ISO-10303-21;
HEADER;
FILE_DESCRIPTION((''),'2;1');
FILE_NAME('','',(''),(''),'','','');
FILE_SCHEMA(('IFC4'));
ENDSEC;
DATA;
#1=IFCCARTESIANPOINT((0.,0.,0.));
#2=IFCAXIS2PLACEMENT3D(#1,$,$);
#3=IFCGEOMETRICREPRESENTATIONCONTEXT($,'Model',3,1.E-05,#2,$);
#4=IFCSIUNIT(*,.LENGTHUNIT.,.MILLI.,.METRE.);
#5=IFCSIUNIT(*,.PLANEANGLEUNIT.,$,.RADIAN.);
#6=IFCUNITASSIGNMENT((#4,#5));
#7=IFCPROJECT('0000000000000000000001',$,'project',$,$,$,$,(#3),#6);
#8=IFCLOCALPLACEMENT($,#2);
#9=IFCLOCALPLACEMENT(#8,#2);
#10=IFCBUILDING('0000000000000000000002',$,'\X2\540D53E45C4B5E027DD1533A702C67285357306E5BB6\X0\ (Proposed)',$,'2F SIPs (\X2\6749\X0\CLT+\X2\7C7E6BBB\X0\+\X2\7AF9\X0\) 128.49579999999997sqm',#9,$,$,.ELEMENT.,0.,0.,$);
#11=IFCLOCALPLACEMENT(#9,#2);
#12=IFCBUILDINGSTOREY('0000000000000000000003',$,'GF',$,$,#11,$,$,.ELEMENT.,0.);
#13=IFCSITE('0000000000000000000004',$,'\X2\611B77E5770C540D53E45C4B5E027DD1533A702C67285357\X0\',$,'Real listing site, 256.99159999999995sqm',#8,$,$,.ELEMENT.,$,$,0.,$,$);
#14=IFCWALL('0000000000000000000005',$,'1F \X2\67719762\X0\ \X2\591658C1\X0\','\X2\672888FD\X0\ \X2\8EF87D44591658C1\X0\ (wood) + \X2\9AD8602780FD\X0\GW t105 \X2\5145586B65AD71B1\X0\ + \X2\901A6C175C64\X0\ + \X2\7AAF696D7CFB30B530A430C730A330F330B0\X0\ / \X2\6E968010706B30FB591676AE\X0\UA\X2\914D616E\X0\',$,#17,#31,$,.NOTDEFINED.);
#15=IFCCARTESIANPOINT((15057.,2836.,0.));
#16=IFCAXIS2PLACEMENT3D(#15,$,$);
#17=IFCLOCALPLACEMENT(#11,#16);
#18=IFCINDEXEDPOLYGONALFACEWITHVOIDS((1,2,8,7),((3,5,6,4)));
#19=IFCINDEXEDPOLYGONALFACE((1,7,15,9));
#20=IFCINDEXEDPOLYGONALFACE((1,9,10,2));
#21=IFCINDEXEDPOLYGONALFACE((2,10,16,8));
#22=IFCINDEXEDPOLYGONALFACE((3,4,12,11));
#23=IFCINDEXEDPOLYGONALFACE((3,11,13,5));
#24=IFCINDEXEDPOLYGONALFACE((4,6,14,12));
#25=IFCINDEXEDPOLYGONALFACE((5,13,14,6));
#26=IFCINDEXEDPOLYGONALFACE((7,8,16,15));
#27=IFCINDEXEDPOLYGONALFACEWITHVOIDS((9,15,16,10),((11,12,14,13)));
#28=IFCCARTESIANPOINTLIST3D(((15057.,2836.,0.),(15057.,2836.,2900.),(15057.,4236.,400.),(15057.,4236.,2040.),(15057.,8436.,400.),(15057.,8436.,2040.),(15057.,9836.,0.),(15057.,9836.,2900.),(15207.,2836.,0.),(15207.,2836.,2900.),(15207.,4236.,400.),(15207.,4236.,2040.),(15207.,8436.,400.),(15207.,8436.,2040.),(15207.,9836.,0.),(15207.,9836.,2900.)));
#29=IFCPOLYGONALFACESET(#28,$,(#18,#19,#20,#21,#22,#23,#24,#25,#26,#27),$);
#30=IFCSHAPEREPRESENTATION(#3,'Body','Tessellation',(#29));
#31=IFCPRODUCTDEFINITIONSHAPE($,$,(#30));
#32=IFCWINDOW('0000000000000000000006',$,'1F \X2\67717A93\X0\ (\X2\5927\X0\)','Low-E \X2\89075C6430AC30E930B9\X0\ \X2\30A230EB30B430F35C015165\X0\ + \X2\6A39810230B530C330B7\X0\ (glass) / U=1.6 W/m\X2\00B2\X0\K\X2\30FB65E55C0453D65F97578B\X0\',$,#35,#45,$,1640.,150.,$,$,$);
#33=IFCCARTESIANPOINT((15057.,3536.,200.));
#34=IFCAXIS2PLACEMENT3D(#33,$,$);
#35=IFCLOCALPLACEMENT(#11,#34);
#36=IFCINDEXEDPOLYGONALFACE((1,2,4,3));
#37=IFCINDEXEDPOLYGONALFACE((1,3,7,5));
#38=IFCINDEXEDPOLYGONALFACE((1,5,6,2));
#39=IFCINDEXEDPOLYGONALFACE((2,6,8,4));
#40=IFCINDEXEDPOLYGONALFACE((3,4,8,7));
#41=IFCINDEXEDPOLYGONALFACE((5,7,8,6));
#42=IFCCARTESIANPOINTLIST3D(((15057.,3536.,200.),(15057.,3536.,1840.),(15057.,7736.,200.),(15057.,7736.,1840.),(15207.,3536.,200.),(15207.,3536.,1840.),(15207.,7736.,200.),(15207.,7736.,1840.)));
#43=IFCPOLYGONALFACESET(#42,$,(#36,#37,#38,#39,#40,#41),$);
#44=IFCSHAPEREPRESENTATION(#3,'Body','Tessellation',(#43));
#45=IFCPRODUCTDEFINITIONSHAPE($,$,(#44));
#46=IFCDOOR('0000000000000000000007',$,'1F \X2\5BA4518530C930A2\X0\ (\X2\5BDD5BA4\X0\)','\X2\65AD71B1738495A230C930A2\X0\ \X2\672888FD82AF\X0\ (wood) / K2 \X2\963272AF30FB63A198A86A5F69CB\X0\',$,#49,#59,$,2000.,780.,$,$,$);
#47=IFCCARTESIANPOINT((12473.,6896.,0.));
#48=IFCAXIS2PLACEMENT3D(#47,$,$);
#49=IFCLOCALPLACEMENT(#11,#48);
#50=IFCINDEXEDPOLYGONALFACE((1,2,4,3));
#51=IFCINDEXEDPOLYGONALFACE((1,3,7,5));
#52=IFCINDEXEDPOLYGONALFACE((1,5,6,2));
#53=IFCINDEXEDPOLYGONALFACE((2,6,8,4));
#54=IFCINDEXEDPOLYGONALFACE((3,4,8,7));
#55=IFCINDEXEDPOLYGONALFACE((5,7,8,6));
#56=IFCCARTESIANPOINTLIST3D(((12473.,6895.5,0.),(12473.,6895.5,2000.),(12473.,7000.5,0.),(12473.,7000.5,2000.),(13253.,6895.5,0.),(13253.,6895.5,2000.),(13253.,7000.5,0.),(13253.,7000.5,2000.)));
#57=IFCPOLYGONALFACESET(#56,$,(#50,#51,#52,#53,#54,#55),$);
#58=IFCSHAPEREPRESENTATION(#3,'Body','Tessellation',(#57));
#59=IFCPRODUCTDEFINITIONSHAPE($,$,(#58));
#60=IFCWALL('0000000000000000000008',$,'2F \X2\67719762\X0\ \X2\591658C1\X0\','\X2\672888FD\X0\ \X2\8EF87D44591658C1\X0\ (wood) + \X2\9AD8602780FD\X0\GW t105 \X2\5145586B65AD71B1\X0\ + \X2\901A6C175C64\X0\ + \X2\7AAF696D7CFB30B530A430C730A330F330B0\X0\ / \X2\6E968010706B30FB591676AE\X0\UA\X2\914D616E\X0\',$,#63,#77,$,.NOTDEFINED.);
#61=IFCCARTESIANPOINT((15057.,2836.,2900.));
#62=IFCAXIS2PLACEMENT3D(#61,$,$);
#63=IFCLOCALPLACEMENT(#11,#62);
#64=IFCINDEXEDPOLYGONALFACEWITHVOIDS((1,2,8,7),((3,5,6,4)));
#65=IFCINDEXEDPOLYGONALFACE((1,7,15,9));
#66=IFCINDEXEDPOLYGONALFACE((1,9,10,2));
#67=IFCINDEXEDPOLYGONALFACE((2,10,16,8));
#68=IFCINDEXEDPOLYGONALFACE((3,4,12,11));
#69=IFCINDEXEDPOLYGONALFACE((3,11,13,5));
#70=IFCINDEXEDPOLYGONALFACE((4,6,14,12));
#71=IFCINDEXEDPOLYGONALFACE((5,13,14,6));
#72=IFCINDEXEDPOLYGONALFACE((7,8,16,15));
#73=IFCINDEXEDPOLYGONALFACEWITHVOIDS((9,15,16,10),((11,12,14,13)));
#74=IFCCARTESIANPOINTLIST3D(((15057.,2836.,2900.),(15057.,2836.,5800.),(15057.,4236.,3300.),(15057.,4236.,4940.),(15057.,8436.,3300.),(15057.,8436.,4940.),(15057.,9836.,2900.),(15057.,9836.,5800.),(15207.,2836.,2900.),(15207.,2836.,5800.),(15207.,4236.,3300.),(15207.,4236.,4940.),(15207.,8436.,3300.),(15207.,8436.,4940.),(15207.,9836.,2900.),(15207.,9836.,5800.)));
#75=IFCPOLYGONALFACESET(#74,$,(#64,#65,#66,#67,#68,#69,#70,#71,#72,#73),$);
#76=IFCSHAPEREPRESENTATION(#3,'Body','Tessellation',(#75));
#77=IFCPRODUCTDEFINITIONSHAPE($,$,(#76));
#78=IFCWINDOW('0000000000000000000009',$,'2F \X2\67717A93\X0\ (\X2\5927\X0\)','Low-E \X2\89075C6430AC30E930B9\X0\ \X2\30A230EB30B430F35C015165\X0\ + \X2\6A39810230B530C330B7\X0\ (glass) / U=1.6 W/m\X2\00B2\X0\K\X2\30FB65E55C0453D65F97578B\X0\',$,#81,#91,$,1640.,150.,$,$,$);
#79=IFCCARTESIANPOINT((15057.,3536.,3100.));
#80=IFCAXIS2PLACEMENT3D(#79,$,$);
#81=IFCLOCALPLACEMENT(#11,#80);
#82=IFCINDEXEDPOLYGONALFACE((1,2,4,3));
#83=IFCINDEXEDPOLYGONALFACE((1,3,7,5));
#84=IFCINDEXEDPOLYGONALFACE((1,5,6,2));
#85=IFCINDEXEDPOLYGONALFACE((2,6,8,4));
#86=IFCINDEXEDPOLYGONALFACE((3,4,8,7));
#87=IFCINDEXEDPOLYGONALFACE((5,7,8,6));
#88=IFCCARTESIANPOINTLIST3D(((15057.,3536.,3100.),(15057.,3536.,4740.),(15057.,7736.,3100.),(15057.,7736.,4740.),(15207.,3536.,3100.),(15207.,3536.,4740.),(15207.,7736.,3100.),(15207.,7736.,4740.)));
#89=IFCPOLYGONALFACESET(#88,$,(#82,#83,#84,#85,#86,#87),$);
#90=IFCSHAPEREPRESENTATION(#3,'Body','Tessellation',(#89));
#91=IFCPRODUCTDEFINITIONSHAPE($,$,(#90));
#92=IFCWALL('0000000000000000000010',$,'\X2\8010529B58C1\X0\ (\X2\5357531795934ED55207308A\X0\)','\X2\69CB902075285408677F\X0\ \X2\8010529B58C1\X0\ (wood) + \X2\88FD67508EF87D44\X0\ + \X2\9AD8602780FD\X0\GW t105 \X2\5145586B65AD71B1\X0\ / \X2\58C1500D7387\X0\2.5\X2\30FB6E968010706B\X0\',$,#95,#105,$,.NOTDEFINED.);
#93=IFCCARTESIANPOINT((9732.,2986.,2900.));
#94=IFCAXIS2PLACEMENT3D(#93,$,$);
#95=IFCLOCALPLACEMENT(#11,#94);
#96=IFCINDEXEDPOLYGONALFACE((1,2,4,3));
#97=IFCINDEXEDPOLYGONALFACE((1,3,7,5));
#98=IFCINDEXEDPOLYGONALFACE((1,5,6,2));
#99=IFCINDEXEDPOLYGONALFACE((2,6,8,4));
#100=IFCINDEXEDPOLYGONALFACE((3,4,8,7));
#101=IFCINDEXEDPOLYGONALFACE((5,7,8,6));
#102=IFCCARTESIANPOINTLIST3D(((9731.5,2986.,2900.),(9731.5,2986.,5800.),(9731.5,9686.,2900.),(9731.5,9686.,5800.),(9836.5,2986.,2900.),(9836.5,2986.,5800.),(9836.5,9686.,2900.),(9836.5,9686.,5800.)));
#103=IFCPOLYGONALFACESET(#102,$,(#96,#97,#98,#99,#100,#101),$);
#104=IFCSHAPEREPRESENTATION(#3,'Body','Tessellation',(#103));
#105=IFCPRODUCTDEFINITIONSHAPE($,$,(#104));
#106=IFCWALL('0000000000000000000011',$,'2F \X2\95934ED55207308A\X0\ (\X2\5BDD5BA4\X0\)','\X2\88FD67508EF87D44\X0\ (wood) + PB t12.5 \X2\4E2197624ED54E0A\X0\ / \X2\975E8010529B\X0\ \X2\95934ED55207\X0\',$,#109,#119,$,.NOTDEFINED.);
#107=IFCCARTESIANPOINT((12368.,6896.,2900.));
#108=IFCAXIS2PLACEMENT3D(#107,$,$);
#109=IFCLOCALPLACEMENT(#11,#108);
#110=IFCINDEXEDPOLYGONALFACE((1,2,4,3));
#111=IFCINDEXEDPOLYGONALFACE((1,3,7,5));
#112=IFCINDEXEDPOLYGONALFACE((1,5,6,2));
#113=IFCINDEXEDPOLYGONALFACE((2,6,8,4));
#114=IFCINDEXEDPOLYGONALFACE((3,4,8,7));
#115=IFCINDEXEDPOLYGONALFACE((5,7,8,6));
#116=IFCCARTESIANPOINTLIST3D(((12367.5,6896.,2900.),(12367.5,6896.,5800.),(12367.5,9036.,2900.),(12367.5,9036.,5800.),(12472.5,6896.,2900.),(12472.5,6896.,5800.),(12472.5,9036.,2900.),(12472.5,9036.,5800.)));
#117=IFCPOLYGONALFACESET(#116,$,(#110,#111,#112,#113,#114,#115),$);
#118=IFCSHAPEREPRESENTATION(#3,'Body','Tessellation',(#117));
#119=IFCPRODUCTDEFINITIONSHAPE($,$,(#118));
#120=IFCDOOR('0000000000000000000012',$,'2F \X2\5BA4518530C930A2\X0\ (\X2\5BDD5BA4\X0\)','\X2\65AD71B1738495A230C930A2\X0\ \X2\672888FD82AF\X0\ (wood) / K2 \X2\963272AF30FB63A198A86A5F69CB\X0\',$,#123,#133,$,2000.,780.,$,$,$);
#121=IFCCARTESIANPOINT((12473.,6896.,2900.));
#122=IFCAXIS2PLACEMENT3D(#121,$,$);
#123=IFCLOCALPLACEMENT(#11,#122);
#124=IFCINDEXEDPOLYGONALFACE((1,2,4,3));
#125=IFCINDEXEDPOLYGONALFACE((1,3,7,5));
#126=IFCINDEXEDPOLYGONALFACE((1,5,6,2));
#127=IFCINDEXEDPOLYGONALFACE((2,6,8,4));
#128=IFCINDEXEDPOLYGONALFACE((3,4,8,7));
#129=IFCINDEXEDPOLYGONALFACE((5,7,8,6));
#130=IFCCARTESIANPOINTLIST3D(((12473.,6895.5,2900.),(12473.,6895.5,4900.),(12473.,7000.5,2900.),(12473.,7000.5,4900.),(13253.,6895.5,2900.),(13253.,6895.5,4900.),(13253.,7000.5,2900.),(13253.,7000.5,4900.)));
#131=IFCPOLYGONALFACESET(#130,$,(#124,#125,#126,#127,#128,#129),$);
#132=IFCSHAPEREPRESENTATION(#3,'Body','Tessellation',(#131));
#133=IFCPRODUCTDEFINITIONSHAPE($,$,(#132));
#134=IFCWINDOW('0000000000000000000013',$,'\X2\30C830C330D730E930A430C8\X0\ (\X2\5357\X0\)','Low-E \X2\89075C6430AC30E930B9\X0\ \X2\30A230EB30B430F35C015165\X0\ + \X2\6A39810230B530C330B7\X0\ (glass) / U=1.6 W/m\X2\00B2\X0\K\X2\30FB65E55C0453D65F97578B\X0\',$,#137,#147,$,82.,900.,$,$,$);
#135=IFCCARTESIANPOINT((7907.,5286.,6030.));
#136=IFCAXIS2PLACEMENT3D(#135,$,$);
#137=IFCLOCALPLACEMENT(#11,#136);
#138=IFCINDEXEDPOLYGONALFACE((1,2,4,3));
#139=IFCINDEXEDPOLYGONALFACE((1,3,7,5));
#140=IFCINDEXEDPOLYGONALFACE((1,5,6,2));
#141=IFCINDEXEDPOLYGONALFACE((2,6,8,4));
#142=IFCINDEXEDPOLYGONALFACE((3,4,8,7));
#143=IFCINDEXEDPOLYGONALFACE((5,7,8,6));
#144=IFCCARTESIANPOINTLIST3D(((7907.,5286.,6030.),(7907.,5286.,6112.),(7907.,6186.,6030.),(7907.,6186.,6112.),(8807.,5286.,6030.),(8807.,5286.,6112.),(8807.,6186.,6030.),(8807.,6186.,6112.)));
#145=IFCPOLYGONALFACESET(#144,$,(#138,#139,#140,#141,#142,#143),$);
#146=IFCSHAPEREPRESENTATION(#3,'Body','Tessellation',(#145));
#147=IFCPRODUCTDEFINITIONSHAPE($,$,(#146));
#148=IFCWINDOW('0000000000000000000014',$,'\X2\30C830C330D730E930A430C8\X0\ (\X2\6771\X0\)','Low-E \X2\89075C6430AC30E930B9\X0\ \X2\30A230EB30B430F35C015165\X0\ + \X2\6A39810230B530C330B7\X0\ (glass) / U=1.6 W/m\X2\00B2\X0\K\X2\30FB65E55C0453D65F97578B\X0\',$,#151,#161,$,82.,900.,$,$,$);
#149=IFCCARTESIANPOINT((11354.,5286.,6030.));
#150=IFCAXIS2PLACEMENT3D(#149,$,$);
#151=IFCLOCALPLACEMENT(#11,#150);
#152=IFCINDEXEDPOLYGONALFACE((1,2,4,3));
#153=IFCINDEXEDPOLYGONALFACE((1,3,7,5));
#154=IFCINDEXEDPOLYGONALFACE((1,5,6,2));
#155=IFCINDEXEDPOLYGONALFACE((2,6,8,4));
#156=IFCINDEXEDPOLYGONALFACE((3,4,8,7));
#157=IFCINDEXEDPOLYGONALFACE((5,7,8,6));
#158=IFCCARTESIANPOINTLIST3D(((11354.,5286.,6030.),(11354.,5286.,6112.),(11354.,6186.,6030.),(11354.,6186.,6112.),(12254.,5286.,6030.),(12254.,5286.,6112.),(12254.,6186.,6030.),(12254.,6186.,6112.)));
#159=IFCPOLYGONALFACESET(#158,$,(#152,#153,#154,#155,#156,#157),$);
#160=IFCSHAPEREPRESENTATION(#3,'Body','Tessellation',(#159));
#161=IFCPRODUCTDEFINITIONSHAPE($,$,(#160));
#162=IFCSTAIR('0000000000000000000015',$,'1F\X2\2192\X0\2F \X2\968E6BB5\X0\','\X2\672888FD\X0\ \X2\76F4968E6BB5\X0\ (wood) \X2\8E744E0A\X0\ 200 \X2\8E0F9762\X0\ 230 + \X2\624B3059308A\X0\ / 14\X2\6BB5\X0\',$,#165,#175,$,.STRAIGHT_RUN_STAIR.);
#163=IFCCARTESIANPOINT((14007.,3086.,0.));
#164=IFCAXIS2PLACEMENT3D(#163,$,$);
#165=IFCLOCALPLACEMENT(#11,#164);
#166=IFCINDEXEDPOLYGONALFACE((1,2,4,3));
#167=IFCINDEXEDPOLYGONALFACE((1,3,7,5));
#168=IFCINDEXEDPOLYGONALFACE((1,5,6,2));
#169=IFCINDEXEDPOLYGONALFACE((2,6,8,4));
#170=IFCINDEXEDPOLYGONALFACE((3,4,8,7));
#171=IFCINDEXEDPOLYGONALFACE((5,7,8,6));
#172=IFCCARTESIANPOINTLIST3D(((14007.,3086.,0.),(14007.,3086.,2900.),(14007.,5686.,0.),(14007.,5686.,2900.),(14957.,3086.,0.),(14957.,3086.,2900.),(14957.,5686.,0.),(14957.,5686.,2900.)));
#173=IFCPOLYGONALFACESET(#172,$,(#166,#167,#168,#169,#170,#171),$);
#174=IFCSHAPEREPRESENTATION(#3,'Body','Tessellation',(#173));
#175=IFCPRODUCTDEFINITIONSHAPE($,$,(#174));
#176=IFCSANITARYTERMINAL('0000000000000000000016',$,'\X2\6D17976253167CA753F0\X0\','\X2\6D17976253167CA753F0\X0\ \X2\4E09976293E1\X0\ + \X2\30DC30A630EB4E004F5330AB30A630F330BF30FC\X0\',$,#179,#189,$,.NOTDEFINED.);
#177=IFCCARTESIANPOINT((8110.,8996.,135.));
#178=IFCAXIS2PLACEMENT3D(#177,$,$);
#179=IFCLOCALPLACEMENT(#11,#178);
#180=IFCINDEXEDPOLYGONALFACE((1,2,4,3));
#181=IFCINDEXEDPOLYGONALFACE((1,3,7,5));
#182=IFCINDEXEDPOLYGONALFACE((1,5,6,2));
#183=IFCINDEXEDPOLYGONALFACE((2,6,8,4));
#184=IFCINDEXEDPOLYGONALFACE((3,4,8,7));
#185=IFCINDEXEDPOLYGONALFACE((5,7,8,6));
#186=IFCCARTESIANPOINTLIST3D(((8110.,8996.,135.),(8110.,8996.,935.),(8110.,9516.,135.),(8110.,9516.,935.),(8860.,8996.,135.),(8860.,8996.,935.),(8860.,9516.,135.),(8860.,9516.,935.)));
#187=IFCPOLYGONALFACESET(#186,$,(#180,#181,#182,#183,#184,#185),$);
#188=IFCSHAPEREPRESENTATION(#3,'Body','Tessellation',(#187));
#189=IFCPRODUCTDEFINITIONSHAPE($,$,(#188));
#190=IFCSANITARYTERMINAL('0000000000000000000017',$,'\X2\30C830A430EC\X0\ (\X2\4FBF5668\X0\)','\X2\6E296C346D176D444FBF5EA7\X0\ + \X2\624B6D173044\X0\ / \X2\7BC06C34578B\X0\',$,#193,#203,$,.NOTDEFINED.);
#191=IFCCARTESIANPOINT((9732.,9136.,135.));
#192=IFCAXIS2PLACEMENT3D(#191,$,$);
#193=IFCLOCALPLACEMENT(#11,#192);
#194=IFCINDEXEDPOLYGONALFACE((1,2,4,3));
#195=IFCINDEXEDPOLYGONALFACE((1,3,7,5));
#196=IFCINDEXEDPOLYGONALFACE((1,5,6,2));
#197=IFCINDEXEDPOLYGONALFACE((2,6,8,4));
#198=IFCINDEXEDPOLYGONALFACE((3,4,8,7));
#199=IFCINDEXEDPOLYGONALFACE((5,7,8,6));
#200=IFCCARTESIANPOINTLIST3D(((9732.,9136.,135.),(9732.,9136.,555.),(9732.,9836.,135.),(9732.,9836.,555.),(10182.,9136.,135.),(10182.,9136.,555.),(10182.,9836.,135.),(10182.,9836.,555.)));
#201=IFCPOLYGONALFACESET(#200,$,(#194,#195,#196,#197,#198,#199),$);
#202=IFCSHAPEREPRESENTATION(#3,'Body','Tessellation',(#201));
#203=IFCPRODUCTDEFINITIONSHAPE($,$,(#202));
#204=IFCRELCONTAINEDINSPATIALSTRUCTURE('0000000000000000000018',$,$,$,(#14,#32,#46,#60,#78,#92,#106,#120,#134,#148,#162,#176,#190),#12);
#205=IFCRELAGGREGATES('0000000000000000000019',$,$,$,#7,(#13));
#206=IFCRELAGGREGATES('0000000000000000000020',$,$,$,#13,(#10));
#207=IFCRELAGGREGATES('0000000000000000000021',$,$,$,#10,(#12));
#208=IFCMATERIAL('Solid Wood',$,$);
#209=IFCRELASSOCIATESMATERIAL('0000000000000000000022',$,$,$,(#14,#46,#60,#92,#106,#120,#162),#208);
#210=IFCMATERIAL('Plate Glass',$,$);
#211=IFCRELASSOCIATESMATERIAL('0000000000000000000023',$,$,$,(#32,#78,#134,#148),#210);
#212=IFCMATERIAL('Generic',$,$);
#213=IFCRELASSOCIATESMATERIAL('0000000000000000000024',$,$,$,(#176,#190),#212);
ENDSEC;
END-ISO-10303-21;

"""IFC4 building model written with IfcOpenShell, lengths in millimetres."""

from ifc_helpers import new_model, si_unit, frame, frame_2d, origin, place, context, project, spatial, rectangle, extrude, material, element, fill, save


model = new_model("IFC4")

# Units and contexts
model_context = context("Model", 3, precision=1e-05, world=origin())
ifc_project = project(units=[si_unit("LENGTHUNIT", "METRE", prefix="MILLI"), si_unit("PLANEANGLEUNIT", "RADIAN")], contexts=[model_context])

# Site, building, storey
site_placement = place(None, origin())
site = spatial("IfcSite", under=ifc_project, at=site_placement, Name="愛知県名古屋市緑区瀬木南", ObjectType="Real listing site, 256.99159999999995sqm", CompositionType="ELEMENT", RefElevation=0.0)
building_placement = place(site_placement, origin())
building = spatial("IfcBuilding", under=site, at=building_placement, Name="名古屋市緑区瀬木南の家 (Proposed)", ObjectType="2F SIPs (杉CLT+籾殻+竹) 128.49579999999997sqm", CompositionType="ELEMENT", ElevationOfRefHeight=0.0, ElevationOfTerrain=0.0)
storey_placement = place(building_placement, origin())
storey = spatial("IfcBuildingStorey", under=building, at=storey_placement, Name="GF", CompositionType="ELEMENT", Elevation=0.0)

# Wall, opening, window
ifc_material_1 = material(Name="Solid Wood")
wall_1_placement = place(storey_placement, frame((15057.0, 2836.0, 0.0)))
wall_1 = element("IfcWall", 1, at=wall_1_placement, inside=storey, material=ifc_material_1, Name="1F 東面 外壁", Description="木製 軸組外壁 (wood) + 高性能GW t105 充填断熱 + 通気層 + 窯業系サイディング / 準耐火・外皮UA配慮", PredefinedType="NOTDEFINED", context=model_context, shape_type="SweptSolid", body=[
    extrude(rectangle(XDim=150.0, YDim=7000.0, at=frame_2d((75.0, 3500.0))), frame((15057.0, 2836.0, 0.0)), (0.0, 0.0, 1.0), 2900.0),
])
opening_1_placement = place(storey_placement, frame((15057.0, 3536.0, 200.0)))
opening_1 = element("IfcOpeningElement", 2, at=opening_1_placement, cuts=wall_1, PredefinedType="NOTDEFINED", context=model_context, shape_type="SweptSolid", body=[
    extrude(rectangle(XDim=150.0, YDim=4200.0, at=frame_2d((75.0, 2100.0))), frame((15057.0, 3536.0, 200.0)), (0.0, 0.0, 1.0), 1640.0),
])
ifc_material_2 = material(Name="Plate Glass")
window_1_placement = place(storey_placement, frame((15057.0, 3536.0, 200.0)))
window_1 = element("IfcWindow", 3, at=window_1_placement, inside=storey, material=ifc_material_2, Name="1F 東窓 (大)", Description="Low-E 複層ガラス アルゴン封入 + 樹脂サッシ (glass) / U=1.6 W/m²K・日射取得型", OverallHeight=1640.0, OverallWidth=150.0, context=model_context, shape_type="SweptSolid", body=[
    extrude(rectangle(XDim=150.0, YDim=4200.0, at=frame_2d((75.0, 2100.0))), frame((15057.0, 3536.0, 200.0)), (0.0, 0.0, 1.0), 1640.0),
])
fill(opening_1, window_1)

# Door
door_1_placement = place(storey_placement, frame((12473.0, 6896.0, 0.0)))
element("IfcDoor", 4, at=door_1_placement, inside=storey, material=ifc_material_1, Name="1F 室内ドア (寝室)", Description="断熱玄関ドア 木製芯 (wood) / K2 防犯・採風機構", OverallHeight=2000.0, OverallWidth=780.0, context=model_context, shape_type="SweptSolid", body=[
    extrude(rectangle(XDim=780.0, YDim=105.0, at=frame_2d((390.0, 52.0))), frame((12473.0, 6896.0, 0.0)), (0.0, 0.0, 1.0), 2000.0),
])

# Wall, opening, window
wall_2_placement = place(storey_placement, frame((15057.0, 2836.0, 2900.0)))
wall_2 = element("IfcWall", 5, at=wall_2_placement, inside=storey, material=ifc_material_1, Name="2F 東面 外壁", Description="木製 軸組外壁 (wood) + 高性能GW t105 充填断熱 + 通気層 + 窯業系サイディング / 準耐火・外皮UA配慮", PredefinedType="NOTDEFINED", context=model_context, shape_type="SweptSolid", body=[
    extrude(rectangle(XDim=150.0, YDim=7000.0, at=frame_2d((75.0, 3500.0))), frame((15057.0, 2836.0, 2900.0)), (0.0, 0.0, 1.0), 2900.0),
])
opening_2_placement = place(storey_placement, frame((15057.0, 3536.0, 3100.0)))
opening_2 = element("IfcOpeningElement", 6, at=opening_2_placement, cuts=wall_2, PredefinedType="NOTDEFINED", context=model_context, shape_type="SweptSolid", body=[
    extrude(rectangle(XDim=150.0, YDim=4200.0, at=frame_2d((75.0, 2100.0))), frame((15057.0, 3536.0, 3100.0)), (0.0, 0.0, 1.0), 1640.0),
])
window_2_placement = place(storey_placement, frame((15057.0, 3536.0, 3100.0)))
window_2 = element("IfcWindow", 7, at=window_2_placement, inside=storey, material=ifc_material_2, Name="2F 東窓 (大)", Description="Low-E 複層ガラス アルゴン封入 + 樹脂サッシ (glass) / U=1.6 W/m²K・日射取得型", OverallHeight=1640.0, OverallWidth=150.0, context=model_context, shape_type="SweptSolid", body=[
    extrude(rectangle(XDim=150.0, YDim=4200.0, at=frame_2d((75.0, 2100.0))), frame((15057.0, 3536.0, 3100.0)), (0.0, 0.0, 1.0), 1640.0),
])
fill(opening_2, window_2)

# Walls
wall_3_placement = place(storey_placement, frame((9732.0, 2986.0, 2900.0)))
element("IfcWall", 8, at=wall_3_placement, inside=storey, material=ifc_material_1, Name="耐力壁 (南北間仕切り)", Description="構造用合板 耐力壁 (wood) + 製材軸組 + 高性能GW t105 充填断熱 / 壁倍率2.5・準耐火", PredefinedType="NOTDEFINED", context=model_context, shape_type="SweptSolid", body=[
    extrude(rectangle(XDim=105.0, YDim=6700.0, at=frame_2d((52.0, 3350.0))), frame((9732.0, 2986.0, 2900.0)), (0.0, 0.0, 1.0), 2900.0),
])
wall_4_placement = place(storey_placement, frame((12368.0, 6896.0, 2900.0)))
element("IfcWall", 9, at=wall_4_placement, inside=storey, material=ifc_material_1, Name="2F 間仕切り (寝室)", Description="製材軸組 (wood) + PB t12.5 両面仕上 / 非耐力 間仕切", PredefinedType="NOTDEFINED", context=model_context, shape_type="SweptSolid", body=[
    extrude(rectangle(XDim=105.0, YDim=2140.0, at=frame_2d((52.0, 1070.0))), frame((12368.0, 6896.0, 2900.0)), (0.0, 0.0, 1.0), 2900.0),
])

# Door
door_2_placement = place(storey_placement, frame((12473.0, 6896.0, 2900.0)))
element("IfcDoor", 10, at=door_2_placement, inside=storey, material=ifc_material_1, Name="2F 室内ドア (寝室)", Description="断熱玄関ドア 木製芯 (wood) / K2 防犯・採風機構", OverallHeight=2000.0, OverallWidth=780.0, context=model_context, shape_type="SweptSolid", body=[
    extrude(rectangle(XDim=780.0, YDim=105.0, at=frame_2d((390.0, 52.0))), frame((12473.0, 6896.0, 2900.0)), (0.0, 0.0, 1.0), 2000.0),
])

# Windows
window_3_placement = place(storey_placement, frame((7907.0, 5286.0, 6030.0)))
element("IfcWindow", 11, at=window_3_placement, inside=storey, material=ifc_material_2, Name="トップライト (南)", Description="Low-E 複層ガラス アルゴン封入 + 樹脂サッシ (glass) / U=1.6 W/m²K・日射取得型", OverallHeight=82.0, OverallWidth=900.0, context=model_context, shape_type="SweptSolid", body=[
    extrude(rectangle(XDim=900.0, YDim=900.0, at=frame_2d((450.0, 450.0))), frame((7907.0, 5286.0, 6030.0)), (0.0, 0.0, 1.0), 82.0),
])
window_4_placement = place(storey_placement, frame((11354.0, 5286.0, 6030.0)))
element("IfcWindow", 12, at=window_4_placement, inside=storey, material=ifc_material_2, Name="トップライト (東)", Description="Low-E 複層ガラス アルゴン封入 + 樹脂サッシ (glass) / U=1.6 W/m²K・日射取得型", OverallHeight=82.0, OverallWidth=900.0, context=model_context, shape_type="SweptSolid", body=[
    extrude(rectangle(XDim=900.0, YDim=900.0, at=frame_2d((450.0, 450.0))), frame((11354.0, 5286.0, 6030.0)), (0.0, 0.0, 1.0), 82.0),
])

# Stair
stair_placement = place(storey_placement, frame((14007.0, 3086.0, 0.0)))
element("IfcStair", 13, at=stair_placement, inside=storey, material=ifc_material_1, Name="1F→2F 階段", Description="木製 直階段 (wood) 蹴上 200 踏面 230 + 手すり / 14段", PredefinedType="STRAIGHT_RUN_STAIR", context=model_context, shape_type="SweptSolid", body=[
    extrude(rectangle(XDim=950.0, YDim=2600.0, at=frame_2d((475.0, 1300.0))), frame((14007.0, 3086.0, 0.0)), (0.0, 0.0, 1.0), 2900.0),
])

# Sanitary terminals
ifc_material_3 = material(Name="Generic")
sanitary_terminal_1_placement = place(storey_placement, frame((8110.0, 8996.0, 135.0)))
element("IfcSanitaryTerminal", 14, at=sanitary_terminal_1_placement, inside=storey, material=ifc_material_3, Name="洗面化粧台", Description="洗面化粧台 三面鏡 + ボウル一体カウンター", PredefinedType="NOTDEFINED", context=model_context, shape_type="SweptSolid", body=[
    extrude(rectangle(XDim=750.0, YDim=520.0, at=frame_2d((375.0, 260.0))), frame((8110.0, 8996.0, 135.0)), (0.0, 0.0, 1.0), 800.0),
])
sanitary_terminal_2_placement = place(storey_placement, frame((9732.0, 9136.0, 135.0)))
element("IfcSanitaryTerminal", 15, at=sanitary_terminal_2_placement, inside=storey, material=ifc_material_3, Name="トイレ (便器)", Description="温水洗浄便座 + 手洗い / 節水型", PredefinedType="NOTDEFINED", context=model_context, shape_type="SweptSolid", body=[
    extrude(rectangle(XDim=450.0, YDim=700.0, at=frame_2d((225.0, 350.0))), frame((9732.0, 9136.0, 135.0)), (0.0, 0.0, 1.0), 420.0),
])

save(model, "model.ifc")
